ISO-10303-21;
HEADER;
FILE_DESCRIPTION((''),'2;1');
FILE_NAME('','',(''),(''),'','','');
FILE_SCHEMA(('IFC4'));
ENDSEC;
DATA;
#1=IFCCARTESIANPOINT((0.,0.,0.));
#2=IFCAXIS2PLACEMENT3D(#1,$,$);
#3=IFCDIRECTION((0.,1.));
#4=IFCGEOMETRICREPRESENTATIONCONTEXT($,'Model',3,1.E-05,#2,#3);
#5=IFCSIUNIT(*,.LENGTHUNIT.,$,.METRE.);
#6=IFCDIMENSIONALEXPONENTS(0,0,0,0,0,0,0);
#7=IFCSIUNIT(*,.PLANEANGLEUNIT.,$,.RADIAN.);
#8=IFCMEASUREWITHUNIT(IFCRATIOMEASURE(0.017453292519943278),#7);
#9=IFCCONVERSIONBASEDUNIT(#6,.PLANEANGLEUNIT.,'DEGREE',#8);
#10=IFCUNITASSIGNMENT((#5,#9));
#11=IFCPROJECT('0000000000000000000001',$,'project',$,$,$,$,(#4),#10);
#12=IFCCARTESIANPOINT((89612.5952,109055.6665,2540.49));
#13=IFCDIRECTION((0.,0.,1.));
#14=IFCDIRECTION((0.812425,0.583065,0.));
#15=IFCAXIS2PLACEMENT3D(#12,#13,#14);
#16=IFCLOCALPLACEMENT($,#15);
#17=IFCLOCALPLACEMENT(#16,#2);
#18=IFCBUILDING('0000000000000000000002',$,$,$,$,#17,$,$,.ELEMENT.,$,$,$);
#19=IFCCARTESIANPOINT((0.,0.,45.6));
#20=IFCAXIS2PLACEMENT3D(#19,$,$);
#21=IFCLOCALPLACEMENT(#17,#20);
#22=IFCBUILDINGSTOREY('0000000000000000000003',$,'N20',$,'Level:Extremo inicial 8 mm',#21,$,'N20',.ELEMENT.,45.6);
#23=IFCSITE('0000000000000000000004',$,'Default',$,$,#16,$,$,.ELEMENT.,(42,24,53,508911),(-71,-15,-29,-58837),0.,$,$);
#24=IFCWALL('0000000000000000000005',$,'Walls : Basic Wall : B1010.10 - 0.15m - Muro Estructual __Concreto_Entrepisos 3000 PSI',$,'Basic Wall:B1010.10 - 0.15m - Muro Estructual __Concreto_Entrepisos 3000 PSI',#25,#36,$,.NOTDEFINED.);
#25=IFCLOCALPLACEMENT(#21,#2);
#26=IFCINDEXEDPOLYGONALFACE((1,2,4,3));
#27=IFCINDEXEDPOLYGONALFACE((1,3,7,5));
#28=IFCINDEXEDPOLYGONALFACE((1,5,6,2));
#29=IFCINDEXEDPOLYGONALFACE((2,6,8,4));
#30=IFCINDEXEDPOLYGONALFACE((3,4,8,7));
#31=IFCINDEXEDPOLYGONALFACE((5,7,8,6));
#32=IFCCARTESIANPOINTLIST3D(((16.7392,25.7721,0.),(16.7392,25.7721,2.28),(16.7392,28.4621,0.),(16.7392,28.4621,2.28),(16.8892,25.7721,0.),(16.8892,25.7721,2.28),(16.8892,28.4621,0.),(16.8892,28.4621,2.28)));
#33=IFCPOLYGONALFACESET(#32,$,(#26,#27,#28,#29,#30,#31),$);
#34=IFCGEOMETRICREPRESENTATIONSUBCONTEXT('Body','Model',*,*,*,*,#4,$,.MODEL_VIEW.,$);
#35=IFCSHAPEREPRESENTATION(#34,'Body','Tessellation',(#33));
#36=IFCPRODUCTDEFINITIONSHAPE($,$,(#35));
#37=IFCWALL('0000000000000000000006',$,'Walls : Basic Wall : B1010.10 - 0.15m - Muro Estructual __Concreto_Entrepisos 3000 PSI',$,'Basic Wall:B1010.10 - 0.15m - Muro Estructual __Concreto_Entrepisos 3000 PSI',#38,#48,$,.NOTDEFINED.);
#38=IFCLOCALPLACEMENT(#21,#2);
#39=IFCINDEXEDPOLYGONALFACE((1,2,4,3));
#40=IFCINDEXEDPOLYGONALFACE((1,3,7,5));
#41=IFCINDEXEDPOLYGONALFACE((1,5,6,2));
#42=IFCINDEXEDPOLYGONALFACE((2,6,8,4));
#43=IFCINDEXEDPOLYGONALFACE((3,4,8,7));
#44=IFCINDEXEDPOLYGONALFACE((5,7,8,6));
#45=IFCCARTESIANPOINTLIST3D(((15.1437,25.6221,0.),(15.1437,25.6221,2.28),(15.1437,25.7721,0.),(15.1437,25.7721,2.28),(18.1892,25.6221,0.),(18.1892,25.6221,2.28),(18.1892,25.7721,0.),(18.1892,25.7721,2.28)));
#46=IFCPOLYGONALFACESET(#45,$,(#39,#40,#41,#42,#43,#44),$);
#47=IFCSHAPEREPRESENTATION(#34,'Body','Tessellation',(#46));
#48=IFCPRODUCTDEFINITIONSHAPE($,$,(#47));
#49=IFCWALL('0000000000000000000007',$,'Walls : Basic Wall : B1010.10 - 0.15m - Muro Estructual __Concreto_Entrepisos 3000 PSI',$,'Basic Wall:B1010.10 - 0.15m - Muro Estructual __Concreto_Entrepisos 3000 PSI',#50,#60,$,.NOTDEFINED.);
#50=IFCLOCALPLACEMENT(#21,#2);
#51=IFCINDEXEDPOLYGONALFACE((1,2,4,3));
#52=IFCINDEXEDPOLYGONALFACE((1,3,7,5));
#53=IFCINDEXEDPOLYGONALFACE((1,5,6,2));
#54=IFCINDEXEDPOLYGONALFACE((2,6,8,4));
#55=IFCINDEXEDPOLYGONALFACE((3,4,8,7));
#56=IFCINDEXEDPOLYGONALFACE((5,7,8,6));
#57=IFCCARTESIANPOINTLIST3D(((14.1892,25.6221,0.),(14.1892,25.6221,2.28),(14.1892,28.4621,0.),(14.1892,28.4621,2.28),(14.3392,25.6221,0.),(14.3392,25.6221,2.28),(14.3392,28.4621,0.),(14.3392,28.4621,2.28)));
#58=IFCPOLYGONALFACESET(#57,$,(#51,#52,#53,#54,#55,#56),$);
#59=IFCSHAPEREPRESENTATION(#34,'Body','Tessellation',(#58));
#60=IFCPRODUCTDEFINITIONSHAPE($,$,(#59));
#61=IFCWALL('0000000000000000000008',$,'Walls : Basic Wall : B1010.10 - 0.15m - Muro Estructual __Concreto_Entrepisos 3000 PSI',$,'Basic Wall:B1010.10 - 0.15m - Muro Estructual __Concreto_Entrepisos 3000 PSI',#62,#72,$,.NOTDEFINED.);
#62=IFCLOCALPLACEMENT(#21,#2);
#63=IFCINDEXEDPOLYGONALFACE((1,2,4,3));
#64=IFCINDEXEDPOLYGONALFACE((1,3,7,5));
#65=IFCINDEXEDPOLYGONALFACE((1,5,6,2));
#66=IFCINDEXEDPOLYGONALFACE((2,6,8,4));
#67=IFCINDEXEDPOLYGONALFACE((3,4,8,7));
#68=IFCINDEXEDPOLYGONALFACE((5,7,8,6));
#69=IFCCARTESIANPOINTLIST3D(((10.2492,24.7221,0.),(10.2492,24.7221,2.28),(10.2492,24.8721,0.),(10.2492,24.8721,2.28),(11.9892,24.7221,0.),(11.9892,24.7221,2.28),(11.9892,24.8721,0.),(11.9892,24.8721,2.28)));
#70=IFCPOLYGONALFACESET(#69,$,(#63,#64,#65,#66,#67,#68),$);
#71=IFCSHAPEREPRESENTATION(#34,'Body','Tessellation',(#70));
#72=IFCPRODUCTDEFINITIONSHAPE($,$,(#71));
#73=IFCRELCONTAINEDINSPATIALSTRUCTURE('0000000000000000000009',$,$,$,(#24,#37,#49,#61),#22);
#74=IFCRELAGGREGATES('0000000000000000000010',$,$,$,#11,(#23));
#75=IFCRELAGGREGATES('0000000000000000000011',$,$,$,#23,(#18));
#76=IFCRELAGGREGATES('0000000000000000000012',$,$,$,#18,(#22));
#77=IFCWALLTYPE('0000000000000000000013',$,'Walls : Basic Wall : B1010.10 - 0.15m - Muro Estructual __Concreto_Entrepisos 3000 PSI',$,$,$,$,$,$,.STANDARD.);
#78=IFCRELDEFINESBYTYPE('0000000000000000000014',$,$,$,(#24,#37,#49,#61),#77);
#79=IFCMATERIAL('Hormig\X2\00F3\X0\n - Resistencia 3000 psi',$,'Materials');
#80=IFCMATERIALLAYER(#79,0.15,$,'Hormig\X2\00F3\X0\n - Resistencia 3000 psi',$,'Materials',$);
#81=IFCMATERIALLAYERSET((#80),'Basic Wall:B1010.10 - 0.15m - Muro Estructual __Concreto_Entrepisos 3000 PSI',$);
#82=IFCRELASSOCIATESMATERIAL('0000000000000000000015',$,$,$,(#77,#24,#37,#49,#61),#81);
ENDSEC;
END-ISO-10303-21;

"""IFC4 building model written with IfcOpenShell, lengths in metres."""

from ifc_helpers import new_model, entity, si_unit, converted_unit, direction, frame, frame_2d, origin, place, context, subcontext, project, spatial, rectangle, extrude, material, layer, layer_set, layer_usage, type_object, element, save


model = new_model("IFC4")

# Units and contexts
model_context = context("Model", 3, precision=1e-05, world=origin(), true_north=direction((0.0, 1.0)))
body_context = subcontext(model_context, "Body", "Model", "MODEL_VIEW")
ifc_project = project(units=[si_unit("LENGTHUNIT", "METRE"), converted_unit("PLANEANGLEUNIT", "DEGREE", entity("IfcRatioMeasure", 0.017453292519943278), si_unit("PLANEANGLEUNIT", "RADIAN"), dimensions=[0, 0, 0, 0, 0, 0, 0])], contexts=[model_context])

# Site, building, storey
site_placement = place(None, frame((89612.5952, 109055.6665, 2540.49), z_axis=(0.0, 0.0, 1.0), x_axis=(0.812425, 0.583065, 0.0)))
site = spatial("IfcSite", under=ifc_project, at=site_placement, Name="Default", CompositionType="ELEMENT", RefLatitude=(42, 24, 53, 508911), RefLongitude=(-71, -15, -29, -58837), RefElevation=0.0)
building_placement = place(site_placement, origin())
building = spatial("IfcBuilding", under=site, at=building_placement, CompositionType="ELEMENT")
storey_placement = place(building_placement, frame((0.0, 0.0, 45.6)))
storey = spatial("IfcBuildingStorey", under=building, at=storey_placement, Name="N20", ObjectType="Level:Extremo inicial 8 mm", LongName="N20", CompositionType="ELEMENT", Elevation=45.6)

# Walls
ifc_material = material(Name="Hormigón - Resistencia 3000 psi", Category="Materials")
ifc_layer_1 = layer(ifc_material, 0.15, Name="Hormigón - Resistencia 3000 psi", Category="Materials")
ifc_layer_set_1 = layer_set([ifc_layer_1], Name="Basic Wall:B1010.10 - 0.15m - Muro Estructual __Concreto_Entrepisos 3000 PSI")
wall_type_1 = type_object("IfcWallType", Name="Walls : Basic Wall : B1010.10 - 0.15m - Muro Estructual __Concreto_Entrepisos 3000 PSI", PredefinedType="STANDARD", material=ifc_layer_set_1)
ifc_layer_usage_1 = layer_usage(ifc_layer_set_1, "AXIS2", "POSITIVE", -0.075)
wall_1_placement = place(storey_placement, frame((16.8142, 28.4621, 0.0), z_axis=(0.0, 0.0, 1.0), x_axis=(0.0, -1.0, 0.0)))
element("IfcWall", 1, at=wall_1_placement, inside=storey, type_object=wall_type_1, material=ifc_layer_usage_1, Name="Walls : Basic Wall : B1010.10 - 0.15m - Muro Estructual __Concreto_Entrepisos 3000 PSI", ObjectType="Basic Wall:B1010.10 - 0.15m - Muro Estructual __Concreto_Entrepisos 3000 PSI", PredefinedType="NOTDEFINED", context=body_context, shape_type="SweptSolid", body=[
    extrude(rectangle(XDim=2.69, YDim=0.15, at=frame_2d((1.345, 0.0), x_axis=(-1.0, 0.0))), origin(), (0.0, 0.0, 1.0), 2.28),
])
ifc_layer_usage_2 = layer_usage(ifc_layer_set_1, "AXIS2", "POSITIVE", -0.075)
wall_2_placement = place(storey_placement, frame((18.1892, 25.6971, 0.0), z_axis=(0.0, 0.0, 1.0), x_axis=(-1.0, 0.0, 0.0)))
element("IfcWall", 2, at=wall_2_placement, inside=storey, type_object=wall_type_1, material=ifc_layer_usage_2, Name="Walls : Basic Wall : B1010.10 - 0.15m - Muro Estructual __Concreto_Entrepisos 3000 PSI", ObjectType="Basic Wall:B1010.10 - 0.15m - Muro Estructual __Concreto_Entrepisos 3000 PSI", PredefinedType="NOTDEFINED", context=body_context, shape_type="SweptSolid", body=[
    extrude(rectangle(XDim=3.0455, YDim=0.15, at=frame_2d((1.5228, 0.0), x_axis=(-1.0, 0.0))), origin(), (0.0, 0.0, 1.0), 2.28),
])
ifc_layer_usage_3 = layer_usage(ifc_layer_set_1, "AXIS2", "POSITIVE", -0.075)
wall_3_placement = place(storey_placement, frame((14.2642, 28.4621, 0.0), z_axis=(0.0, 0.0, 1.0), x_axis=(0.0, -1.0, 0.0)))
element("IfcWall", 3, at=wall_3_placement, inside=storey, type_object=wall_type_1, material=ifc_layer_usage_3, Name="Walls : Basic Wall : B1010.10 - 0.15m - Muro Estructual __Concreto_Entrepisos 3000 PSI", ObjectType="Basic Wall:B1010.10 - 0.15m - Muro Estructual __Concreto_Entrepisos 3000 PSI", PredefinedType="NOTDEFINED", context=body_context, shape_type="SweptSolid", body=[
    extrude(rectangle(XDim=2.84, YDim=0.15, at=frame_2d((1.42, 0.0), x_axis=(-1.0, 0.0))), origin(), (0.0, 0.0, 1.0), 2.28),
])
ifc_layer_usage_4 = layer_usage(ifc_layer_set_1, "AXIS2", "POSITIVE", -0.075)
wall_4_placement = place(storey_placement, frame((11.9892, 24.7971, 0.0), z_axis=(0.0, 0.0, 1.0), x_axis=(-1.0, 0.0, 0.0)))
element("IfcWall", 4, at=wall_4_placement, inside=storey, type_object=wall_type_1, material=ifc_layer_usage_4, Name="Walls : Basic Wall : B1010.10 - 0.15m - Muro Estructual __Concreto_Entrepisos 3000 PSI", ObjectType="Basic Wall:B1010.10 - 0.15m - Muro Estructual __Concreto_Entrepisos 3000 PSI", PredefinedType="NOTDEFINED", context=body_context, shape_type="SweptSolid", body=[
    extrude(rectangle(XDim=1.74, YDim=0.15, at=frame_2d((0.87, 0.0), x_axis=(-1.0, 0.0))), origin(), (0.0, 0.0, 1.0), 2.28),
])

save(model, "model.ifc")
